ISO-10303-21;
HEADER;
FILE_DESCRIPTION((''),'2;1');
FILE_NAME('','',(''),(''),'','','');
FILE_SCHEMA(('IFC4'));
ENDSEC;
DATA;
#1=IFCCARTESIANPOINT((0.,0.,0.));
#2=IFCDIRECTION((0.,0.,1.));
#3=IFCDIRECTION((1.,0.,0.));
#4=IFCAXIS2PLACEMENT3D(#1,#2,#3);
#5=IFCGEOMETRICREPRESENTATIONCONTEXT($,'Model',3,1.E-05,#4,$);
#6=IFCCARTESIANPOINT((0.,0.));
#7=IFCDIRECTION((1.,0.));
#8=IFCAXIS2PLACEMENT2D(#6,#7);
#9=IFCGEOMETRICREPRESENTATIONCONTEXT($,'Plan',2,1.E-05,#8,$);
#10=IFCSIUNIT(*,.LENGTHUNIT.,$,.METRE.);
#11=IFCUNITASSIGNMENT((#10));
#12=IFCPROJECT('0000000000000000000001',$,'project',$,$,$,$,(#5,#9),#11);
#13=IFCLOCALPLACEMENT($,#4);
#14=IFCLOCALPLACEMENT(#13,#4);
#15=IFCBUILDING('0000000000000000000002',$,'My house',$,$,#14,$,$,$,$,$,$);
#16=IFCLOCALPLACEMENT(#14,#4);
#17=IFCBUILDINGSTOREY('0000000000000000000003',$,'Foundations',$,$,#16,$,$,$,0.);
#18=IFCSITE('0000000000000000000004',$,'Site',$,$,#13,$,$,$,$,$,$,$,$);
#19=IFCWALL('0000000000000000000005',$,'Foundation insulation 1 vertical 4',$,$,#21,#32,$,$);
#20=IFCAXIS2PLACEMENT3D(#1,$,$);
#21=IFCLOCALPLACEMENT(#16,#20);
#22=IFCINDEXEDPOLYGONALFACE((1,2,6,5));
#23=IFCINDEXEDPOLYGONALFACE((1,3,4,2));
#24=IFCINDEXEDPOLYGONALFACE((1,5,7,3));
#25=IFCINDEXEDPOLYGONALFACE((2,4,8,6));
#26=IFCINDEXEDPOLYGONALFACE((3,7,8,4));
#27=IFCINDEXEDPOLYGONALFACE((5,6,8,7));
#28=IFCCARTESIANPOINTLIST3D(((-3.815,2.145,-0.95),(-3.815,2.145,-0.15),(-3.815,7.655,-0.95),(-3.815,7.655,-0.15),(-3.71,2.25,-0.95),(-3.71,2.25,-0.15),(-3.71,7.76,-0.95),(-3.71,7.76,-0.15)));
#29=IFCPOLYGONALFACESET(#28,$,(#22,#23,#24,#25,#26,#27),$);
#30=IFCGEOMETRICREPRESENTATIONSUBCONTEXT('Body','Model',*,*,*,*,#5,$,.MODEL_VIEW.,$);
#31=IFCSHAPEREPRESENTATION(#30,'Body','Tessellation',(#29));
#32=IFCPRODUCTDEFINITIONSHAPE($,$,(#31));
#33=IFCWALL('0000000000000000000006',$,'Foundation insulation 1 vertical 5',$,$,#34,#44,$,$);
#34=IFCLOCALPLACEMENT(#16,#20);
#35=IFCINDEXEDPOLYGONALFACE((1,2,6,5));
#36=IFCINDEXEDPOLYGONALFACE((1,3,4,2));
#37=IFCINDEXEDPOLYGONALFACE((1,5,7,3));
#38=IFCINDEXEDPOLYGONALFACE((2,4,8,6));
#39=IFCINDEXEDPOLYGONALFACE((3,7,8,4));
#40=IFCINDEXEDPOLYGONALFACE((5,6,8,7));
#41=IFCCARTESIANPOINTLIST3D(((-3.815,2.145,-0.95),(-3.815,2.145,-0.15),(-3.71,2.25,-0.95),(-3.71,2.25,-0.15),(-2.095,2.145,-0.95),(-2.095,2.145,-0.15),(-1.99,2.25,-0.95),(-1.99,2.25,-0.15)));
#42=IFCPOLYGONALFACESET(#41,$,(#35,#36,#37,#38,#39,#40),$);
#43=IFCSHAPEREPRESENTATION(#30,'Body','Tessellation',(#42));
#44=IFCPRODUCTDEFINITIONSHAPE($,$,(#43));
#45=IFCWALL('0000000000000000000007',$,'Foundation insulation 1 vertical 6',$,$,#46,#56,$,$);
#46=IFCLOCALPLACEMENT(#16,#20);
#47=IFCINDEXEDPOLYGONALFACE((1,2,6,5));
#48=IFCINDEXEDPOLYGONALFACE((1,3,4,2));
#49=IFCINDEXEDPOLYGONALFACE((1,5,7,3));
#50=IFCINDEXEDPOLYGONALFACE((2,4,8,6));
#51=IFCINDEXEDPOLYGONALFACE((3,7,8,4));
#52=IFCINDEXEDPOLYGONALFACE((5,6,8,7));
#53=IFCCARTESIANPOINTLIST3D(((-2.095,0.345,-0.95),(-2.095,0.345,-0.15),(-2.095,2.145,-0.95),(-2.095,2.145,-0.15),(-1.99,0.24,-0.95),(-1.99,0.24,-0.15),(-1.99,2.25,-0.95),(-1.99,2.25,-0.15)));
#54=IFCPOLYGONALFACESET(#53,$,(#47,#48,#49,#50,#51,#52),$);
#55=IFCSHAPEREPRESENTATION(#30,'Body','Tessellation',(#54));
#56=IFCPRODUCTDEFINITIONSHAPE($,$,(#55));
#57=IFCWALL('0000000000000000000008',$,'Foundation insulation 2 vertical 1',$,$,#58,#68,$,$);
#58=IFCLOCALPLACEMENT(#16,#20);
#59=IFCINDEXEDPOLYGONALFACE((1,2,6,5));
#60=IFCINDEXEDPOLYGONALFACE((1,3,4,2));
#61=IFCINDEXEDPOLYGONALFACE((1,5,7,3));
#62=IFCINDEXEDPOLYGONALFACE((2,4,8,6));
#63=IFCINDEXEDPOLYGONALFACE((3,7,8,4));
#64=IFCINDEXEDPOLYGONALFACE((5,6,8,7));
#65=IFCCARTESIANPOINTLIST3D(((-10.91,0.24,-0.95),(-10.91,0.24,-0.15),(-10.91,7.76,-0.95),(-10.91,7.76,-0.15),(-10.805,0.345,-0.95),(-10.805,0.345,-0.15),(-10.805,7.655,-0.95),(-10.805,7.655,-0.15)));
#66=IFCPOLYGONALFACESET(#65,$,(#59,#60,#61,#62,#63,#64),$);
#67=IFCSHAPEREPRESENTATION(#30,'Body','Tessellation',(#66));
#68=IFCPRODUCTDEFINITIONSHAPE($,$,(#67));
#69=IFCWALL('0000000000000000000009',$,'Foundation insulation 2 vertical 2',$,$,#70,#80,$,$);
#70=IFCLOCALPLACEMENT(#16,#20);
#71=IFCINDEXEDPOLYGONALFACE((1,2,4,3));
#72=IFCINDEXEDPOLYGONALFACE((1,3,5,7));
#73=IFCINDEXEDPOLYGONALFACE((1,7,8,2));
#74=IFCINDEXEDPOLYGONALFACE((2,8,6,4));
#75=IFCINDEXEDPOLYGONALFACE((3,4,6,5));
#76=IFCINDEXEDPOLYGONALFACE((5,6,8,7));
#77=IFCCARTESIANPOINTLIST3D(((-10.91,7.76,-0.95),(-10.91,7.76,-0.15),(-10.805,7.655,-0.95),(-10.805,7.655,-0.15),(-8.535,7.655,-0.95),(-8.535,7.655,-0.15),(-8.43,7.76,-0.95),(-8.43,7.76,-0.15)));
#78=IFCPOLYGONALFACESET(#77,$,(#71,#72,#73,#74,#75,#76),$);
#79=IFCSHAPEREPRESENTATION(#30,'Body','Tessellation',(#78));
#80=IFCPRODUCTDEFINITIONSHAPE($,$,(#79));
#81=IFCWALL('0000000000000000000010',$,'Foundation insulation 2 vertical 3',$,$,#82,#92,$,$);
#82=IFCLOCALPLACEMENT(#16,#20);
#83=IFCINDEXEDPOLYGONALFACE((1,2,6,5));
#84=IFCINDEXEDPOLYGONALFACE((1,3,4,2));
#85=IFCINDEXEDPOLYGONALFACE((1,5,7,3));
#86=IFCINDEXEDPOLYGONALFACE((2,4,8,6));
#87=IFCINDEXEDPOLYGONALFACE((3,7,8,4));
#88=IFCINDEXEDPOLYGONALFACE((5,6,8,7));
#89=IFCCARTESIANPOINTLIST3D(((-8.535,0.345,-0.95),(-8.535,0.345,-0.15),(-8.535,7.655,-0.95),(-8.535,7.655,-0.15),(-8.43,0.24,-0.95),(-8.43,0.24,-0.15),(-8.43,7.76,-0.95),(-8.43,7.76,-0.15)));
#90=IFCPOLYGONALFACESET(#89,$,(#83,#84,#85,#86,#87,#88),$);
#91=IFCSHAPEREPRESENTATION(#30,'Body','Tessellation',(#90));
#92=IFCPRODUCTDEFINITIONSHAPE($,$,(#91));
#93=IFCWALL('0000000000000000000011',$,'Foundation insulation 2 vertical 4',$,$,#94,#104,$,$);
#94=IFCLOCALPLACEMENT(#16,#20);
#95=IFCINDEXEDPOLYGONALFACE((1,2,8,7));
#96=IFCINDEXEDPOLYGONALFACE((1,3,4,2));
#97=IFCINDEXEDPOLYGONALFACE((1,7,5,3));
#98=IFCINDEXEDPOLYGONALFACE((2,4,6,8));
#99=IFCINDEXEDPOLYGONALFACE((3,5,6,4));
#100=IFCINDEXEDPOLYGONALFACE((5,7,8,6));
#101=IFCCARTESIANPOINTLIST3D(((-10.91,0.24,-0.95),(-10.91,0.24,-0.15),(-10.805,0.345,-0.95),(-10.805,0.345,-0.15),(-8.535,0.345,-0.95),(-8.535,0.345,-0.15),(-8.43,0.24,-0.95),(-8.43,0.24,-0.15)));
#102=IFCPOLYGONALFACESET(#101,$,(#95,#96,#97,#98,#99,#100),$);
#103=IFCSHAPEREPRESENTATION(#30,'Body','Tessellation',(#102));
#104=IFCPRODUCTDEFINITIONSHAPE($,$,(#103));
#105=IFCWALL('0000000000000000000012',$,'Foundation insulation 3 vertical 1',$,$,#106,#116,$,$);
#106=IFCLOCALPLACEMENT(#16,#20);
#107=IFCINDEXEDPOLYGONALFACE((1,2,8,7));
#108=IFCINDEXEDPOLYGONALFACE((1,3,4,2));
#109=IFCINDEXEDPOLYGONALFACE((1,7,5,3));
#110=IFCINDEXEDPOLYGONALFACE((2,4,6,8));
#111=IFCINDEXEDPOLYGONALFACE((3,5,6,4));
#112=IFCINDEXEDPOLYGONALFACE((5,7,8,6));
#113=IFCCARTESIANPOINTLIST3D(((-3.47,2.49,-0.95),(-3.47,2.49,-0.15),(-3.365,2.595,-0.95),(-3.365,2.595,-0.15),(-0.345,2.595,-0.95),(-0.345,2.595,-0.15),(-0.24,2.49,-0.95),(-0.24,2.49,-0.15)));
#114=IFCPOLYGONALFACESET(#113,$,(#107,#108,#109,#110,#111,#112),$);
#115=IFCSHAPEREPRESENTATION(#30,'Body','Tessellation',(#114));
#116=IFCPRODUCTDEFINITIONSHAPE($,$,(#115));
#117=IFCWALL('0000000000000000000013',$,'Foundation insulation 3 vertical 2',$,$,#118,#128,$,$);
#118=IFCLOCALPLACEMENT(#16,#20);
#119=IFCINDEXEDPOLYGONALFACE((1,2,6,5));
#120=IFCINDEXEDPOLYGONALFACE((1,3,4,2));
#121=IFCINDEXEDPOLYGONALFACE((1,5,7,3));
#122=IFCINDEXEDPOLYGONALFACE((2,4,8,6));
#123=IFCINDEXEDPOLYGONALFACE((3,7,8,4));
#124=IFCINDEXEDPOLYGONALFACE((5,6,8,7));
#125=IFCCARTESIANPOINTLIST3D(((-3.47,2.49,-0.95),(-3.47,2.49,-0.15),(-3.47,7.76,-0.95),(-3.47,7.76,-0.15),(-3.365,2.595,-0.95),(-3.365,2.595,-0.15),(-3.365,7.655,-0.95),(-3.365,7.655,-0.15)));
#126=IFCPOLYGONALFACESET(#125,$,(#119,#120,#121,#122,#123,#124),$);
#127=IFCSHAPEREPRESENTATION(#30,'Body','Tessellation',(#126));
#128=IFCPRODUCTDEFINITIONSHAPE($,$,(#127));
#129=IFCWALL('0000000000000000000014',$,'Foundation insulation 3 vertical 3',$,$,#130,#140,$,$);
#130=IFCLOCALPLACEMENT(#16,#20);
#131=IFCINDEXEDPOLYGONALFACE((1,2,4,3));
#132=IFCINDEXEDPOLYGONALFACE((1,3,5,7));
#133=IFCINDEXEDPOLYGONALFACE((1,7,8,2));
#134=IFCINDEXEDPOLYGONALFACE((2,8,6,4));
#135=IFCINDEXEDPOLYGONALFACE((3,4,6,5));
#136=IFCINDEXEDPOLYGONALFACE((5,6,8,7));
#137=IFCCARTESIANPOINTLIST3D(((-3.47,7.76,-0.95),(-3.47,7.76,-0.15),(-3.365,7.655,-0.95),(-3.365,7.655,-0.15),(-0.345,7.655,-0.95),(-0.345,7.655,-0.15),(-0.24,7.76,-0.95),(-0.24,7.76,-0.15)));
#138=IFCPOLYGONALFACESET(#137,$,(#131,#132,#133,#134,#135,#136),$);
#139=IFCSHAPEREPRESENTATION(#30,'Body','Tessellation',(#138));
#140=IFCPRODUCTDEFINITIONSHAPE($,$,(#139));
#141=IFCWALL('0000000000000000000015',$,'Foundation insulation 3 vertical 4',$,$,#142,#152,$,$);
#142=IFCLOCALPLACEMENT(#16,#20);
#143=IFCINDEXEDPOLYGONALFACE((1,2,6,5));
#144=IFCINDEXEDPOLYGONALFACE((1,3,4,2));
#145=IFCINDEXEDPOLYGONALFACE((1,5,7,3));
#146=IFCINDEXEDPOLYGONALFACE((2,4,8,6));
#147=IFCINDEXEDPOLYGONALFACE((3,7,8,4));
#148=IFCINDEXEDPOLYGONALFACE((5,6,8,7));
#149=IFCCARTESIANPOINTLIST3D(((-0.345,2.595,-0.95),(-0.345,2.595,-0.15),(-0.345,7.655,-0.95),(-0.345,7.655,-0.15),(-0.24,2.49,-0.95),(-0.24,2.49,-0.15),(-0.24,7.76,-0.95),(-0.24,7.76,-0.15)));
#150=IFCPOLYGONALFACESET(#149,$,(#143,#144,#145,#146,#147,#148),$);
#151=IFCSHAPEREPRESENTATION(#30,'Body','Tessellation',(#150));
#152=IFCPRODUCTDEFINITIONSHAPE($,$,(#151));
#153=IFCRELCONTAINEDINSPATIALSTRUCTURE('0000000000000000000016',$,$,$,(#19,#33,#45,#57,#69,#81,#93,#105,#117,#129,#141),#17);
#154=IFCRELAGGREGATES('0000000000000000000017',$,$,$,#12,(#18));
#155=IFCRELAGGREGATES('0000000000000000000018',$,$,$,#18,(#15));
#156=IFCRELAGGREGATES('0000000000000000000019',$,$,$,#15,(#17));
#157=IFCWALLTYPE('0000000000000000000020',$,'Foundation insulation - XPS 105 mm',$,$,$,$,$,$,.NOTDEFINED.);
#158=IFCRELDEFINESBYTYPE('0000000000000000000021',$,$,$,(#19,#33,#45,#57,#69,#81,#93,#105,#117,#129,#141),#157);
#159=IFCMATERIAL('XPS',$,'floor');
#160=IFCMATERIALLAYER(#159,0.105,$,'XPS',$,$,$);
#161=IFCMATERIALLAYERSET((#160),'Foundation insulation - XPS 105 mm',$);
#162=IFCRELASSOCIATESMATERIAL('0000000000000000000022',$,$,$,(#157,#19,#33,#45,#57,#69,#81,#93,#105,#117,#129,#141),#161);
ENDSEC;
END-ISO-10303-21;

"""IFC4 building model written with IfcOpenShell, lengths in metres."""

from ifc_helpers import new_model, si_unit, frame, origin_with_axes, origin_2d_with_axis, place, context, subcontext, project, spatial, line, indexed_curve, outline, extrude, source, transform, mapped, material, layer, layer_set, layer_usage, type_object, element, save


model = new_model("IFC4")

# Units and contexts
model_context = context("Model", 3, precision=1e-05, world=origin_with_axes())
plan_context = context("Plan", 2, precision=1e-05, world=origin_2d_with_axis())
body_context = subcontext(model_context, "Body", "Model", "MODEL_VIEW")
ifc_project = project(units=[si_unit("LENGTHUNIT", "METRE")], contexts=[model_context, plan_context])

# Site, building, storey
site_placement = place(None, origin_with_axes())
site = spatial("IfcSite", under=ifc_project, at=site_placement, Name="Site")
building_placement = place(site_placement, origin_with_axes())
building = spatial("IfcBuilding", under=site, at=building_placement, Name="My house")
storey_placement = place(building_placement, origin_with_axes())
storey = spatial("IfcBuildingStorey", under=building, at=storey_placement, Name="Foundations", Elevation=0.0)

# Shared definitions
ifc_material_1 = material(Name="XPS", Category="floor")

# Walls
ifc_layer_1 = layer(ifc_material_1, 0.105, Name="XPS")
ifc_layer_set_1 = layer_set([ifc_layer_1], Name="Foundation insulation - XPS 105 mm")
wall_type_1 = type_object("IfcWallType", Name="Foundation insulation - XPS 105 mm", PredefinedType="NOTDEFINED", material=ifc_layer_set_1)
ifc_layer_usage_1 = layer_usage(ifc_layer_set_1, "AXIS2", "NEGATIVE", 0.105)
shared_shape_1 = source(origin_with_axes(), body_context, "Body", "SweptSolid", [
    extrude(outline(indexed_curve([(0.0, 0.0), (0.105, 0.105), (5.615, 0.105), (5.51, 0.0)], segments=[line(1, 2, 3, 4, 1)])), origin_with_axes(), (0.0, 0.0, 1.0), 0.8),
])
wall_1_placement = place(storey_placement, frame((-3.71, 7.76, -0.95), z_axis=(0.0, 0.0, 1.0), x_axis=(0.0, 1.0, 0.0)))
element("IfcWall", 1, at=wall_1_placement, inside=storey, type_object=wall_type_1, material=ifc_layer_usage_1, Name="Foundation insulation 1 vertical 4", context=body_context, shape_type="MappedRepresentation", body=[
    mapped(shared_shape_1, transform((0.0, 0.0, 0.0), x_axis=(-1.0, 0.0, 0.0), y_axis=(0.0, 1.0, 0.0), z_axis=(0.0, 0.0, 1.0), scale=1.0)),
])
ifc_layer_usage_2 = layer_usage(ifc_layer_set_1, "AXIS2", "NEGATIVE", 0.105)
shared_shape_2 = source(origin_with_axes(), body_context, "Body", "SweptSolid", [
    extrude(outline(indexed_curve([(0.0, 0.0), (-0.105, 0.105), (1.615, 0.105), (1.72, 0.0)], segments=[line(1, 2, 3, 4, 1)])), origin_with_axes(), (0.0, 0.0, 1.0), 0.8),
])
wall_2_placement = place(storey_placement, frame((-3.71, 2.25, -0.95), z_axis=(0.0, 0.0, 1.0), x_axis=(-1.0, 0.0, 0.0)))
element("IfcWall", 2, at=wall_2_placement, inside=storey, type_object=wall_type_1, material=ifc_layer_usage_2, Name="Foundation insulation 1 vertical 5", context=body_context, shape_type="MappedRepresentation", body=[
    mapped(shared_shape_2, transform((0.0, 0.0, 0.0), x_axis=(-1.0, 0.0, 0.0), y_axis=(0.0, 1.0, 0.0), z_axis=(0.0, 0.0, 1.0), scale=1.0)),
])
ifc_layer_usage_3 = layer_usage(ifc_layer_set_1, "AXIS2", "NEGATIVE", 0.105)
shared_shape_3 = source(origin_with_axes(), body_context, "Body", "SweptSolid", [
    extrude(outline(indexed_curve([(0.0, 0.0), (0.105, 0.105), (1.905, 0.105), (2.01, 0.0)], segments=[line(1, 2, 3, 4, 1)])), origin_with_axes(), (0.0, 0.0, 1.0), 0.8),
])
wall_3_placement = place(storey_placement, frame((-1.99, 2.25, -0.95), z_axis=(0.0, 0.0, 1.0), x_axis=(0.0, 1.0, 0.0)))
element("IfcWall", 3, at=wall_3_placement, inside=storey, type_object=wall_type_1, material=ifc_layer_usage_3, Name="Foundation insulation 1 vertical 6", context=body_context, shape_type="MappedRepresentation", body=[
    mapped(shared_shape_3, transform((0.0, 0.0, 0.0), x_axis=(-1.0, 0.0, 0.0), y_axis=(0.0, 1.0, 0.0), z_axis=(0.0, 0.0, 1.0), scale=1.0)),
])
ifc_layer_usage_4 = layer_usage(ifc_layer_set_1, "AXIS2", "NEGATIVE", 0.105)
shared_shape_4 = source(origin_with_axes(), body_context, "Body", "SweptSolid", [
    extrude(outline(indexed_curve([(0.0, 0.0), (0.105, 0.105), (7.415, 0.105), (7.52, 0.0)], segments=[line(1, 2, 3, 4, 1)])), origin_with_axes(), (0.0, 0.0, 1.0), 0.8),
])
wall_4_placement = place(storey_placement, frame((-10.91, 0.24, -0.95), z_axis=(0.0, 0.0, 1.0), x_axis=(0.0, -1.0, 0.0)))
element("IfcWall", 4, at=wall_4_placement, inside=storey, type_object=wall_type_1, material=ifc_layer_usage_4, Name="Foundation insulation 2 vertical 1", context=body_context, shape_type="MappedRepresentation", body=[
    mapped(shared_shape_4, transform((0.0, 0.0, 0.0), x_axis=(-1.0, 0.0, 0.0), y_axis=(0.0, 1.0, 0.0), z_axis=(0.0, 0.0, 1.0), scale=1.0)),
])
ifc_layer_usage_5 = layer_usage(ifc_layer_set_1, "AXIS2", "NEGATIVE", 0.105)
shared_shape_5 = source(origin_with_axes(), body_context, "Body", "SweptSolid", [
    extrude(outline(indexed_curve([(0.0, 0.0), (0.105, 0.105), (2.375, 0.105), (2.48, 0.0)], segments=[line(1, 2, 3, 4, 1)])), origin_with_axes(), (0.0, 0.0, 1.0), 0.8),
])
wall_5_placement = place(storey_placement, frame((-10.91, 7.76, -0.95), z_axis=(0.0, 0.0, 1.0), x_axis=(-1.0, 0.0, 0.0)))
element("IfcWall", 5, at=wall_5_placement, inside=storey, type_object=wall_type_1, material=ifc_layer_usage_5, Name="Foundation insulation 2 vertical 2", context=body_context, shape_type="MappedRepresentation", body=[
    mapped(shared_shape_5, transform((0.0, 0.0, 0.0), x_axis=(-1.0, 0.0, 0.0), y_axis=(0.0, 1.0, 0.0), z_axis=(0.0, 0.0, 1.0), scale=1.0)),
])
ifc_layer_usage_6 = layer_usage(ifc_layer_set_1, "AXIS2", "NEGATIVE", 0.105)
shared_shape_6 = source(origin_with_axes(), body_context, "Body", "SweptSolid", [
    extrude(outline(indexed_curve([(0.0, 0.0), (0.105, 0.105), (7.415, 0.105), (7.52, 0.0)], segments=[line(1, 2, 3, 4, 1)])), origin_with_axes(), (0.0, 0.0, 1.0), 0.8),
])
wall_6_placement = place(storey_placement, frame((-8.43, 7.76, -0.95), z_axis=(0.0, 0.0, 1.0), x_axis=(0.0, 1.0, 0.0)))
element("IfcWall", 6, at=wall_6_placement, inside=storey, type_object=wall_type_1, material=ifc_layer_usage_6, Name="Foundation insulation 2 vertical 3", context=body_context, shape_type="MappedRepresentation", body=[
    mapped(shared_shape_6, transform((0.0, 0.0, 0.0), x_axis=(-1.0, 0.0, 0.0), y_axis=(0.0, 1.0, 0.0), z_axis=(0.0, 0.0, 1.0), scale=1.0)),
])
ifc_layer_usage_7 = layer_usage(ifc_layer_set_1, "AXIS2", "NEGATIVE", 0.105)
shared_shape_7 = source(origin_with_axes(), body_context, "Body", "SweptSolid", [
    extrude(outline(indexed_curve([(0.0, 0.0), (0.105, 0.105), (2.375, 0.105), (2.48, 0.0)], segments=[line(1, 2, 3, 4, 1)])), origin_with_axes(), (0.0, 0.0, 1.0), 0.8),
])
wall_7_placement = place(storey_placement, frame((-8.43, 0.24, -0.95), z_axis=(0.0, 0.0, 1.0), x_axis=(1.0, 0.0, 0.0)))
element("IfcWall", 7, at=wall_7_placement, inside=storey, type_object=wall_type_1, material=ifc_layer_usage_7, Name="Foundation insulation 2 vertical 4", context=body_context, shape_type="MappedRepresentation", body=[
    mapped(shared_shape_7, transform((0.0, 0.0, 0.0), x_axis=(-1.0, 0.0, 0.0), y_axis=(0.0, 1.0, 0.0), z_axis=(0.0, 0.0, 1.0), scale=1.0)),
])
ifc_layer_usage_8 = layer_usage(ifc_layer_set_1, "AXIS2", "NEGATIVE", 0.105)
shared_shape_8 = source(origin_with_axes(), body_context, "Body", "SweptSolid", [
    extrude(outline(indexed_curve([(0.0, 0.0), (0.105, 0.105), (3.125, 0.105), (3.23, 0.0)], segments=[line(1, 2, 3, 4, 1)])), origin_with_axes(), (0.0, 0.0, 1.0), 0.8),
])
wall_8_placement = place(storey_placement, frame((-0.24, 2.49, -0.95), z_axis=(0.0, 0.0, 1.0), x_axis=(1.0, 0.0, 0.0)))
element("IfcWall", 8, at=wall_8_placement, inside=storey, type_object=wall_type_1, material=ifc_layer_usage_8, Name="Foundation insulation 3 vertical 1", context=body_context, shape_type="MappedRepresentation", body=[
    mapped(shared_shape_8, transform((0.0, 0.0, 0.0), x_axis=(-1.0, 0.0, 0.0), y_axis=(0.0, 1.0, 0.0), z_axis=(0.0, 0.0, 1.0), scale=1.0)),
])
ifc_layer_usage_9 = layer_usage(ifc_layer_set_1, "AXIS2", "NEGATIVE", 0.105)
shared_shape_9 = source(origin_with_axes(), body_context, "Body", "SweptSolid", [
    extrude(outline(indexed_curve([(0.0, 0.0), (0.105, 0.105), (5.165, 0.105), (5.27, 0.0)], segments=[line(1, 2, 3, 4, 1)])), origin_with_axes(), (0.0, 0.0, 1.0), 0.8),
])
wall_9_placement = place(storey_placement, frame((-3.47, 2.49, -0.95), z_axis=(0.0, 0.0, 1.0), x_axis=(0.0, -1.0, 0.0)))
element("IfcWall", 9, at=wall_9_placement, inside=storey, type_object=wall_type_1, material=ifc_layer_usage_9, Name="Foundation insulation 3 vertical 2", context=body_context, shape_type="MappedRepresentation", body=[
    mapped(shared_shape_9, transform((0.0, 0.0, 0.0), x_axis=(-1.0, 0.0, 0.0), y_axis=(0.0, 1.0, 0.0), z_axis=(0.0, 0.0, 1.0), scale=1.0)),
])
ifc_layer_usage_10 = layer_usage(ifc_layer_set_1, "AXIS2", "NEGATIVE", 0.105)
shared_shape_10 = source(origin_with_axes(), body_context, "Body", "SweptSolid", [
    extrude(outline(indexed_curve([(0.0, 0.0), (0.105, 0.105), (3.125, 0.105), (3.23, 0.0)], segments=[line(1, 2, 3, 4, 1)])), origin_with_axes(), (0.0, 0.0, 1.0), 0.8),
])
wall_10_placement = place(storey_placement, frame((-3.47, 7.76, -0.95), z_axis=(0.0, 0.0, 1.0), x_axis=(-1.0, 0.0, 0.0)))
element("IfcWall", 10, at=wall_10_placement, inside=storey, type_object=wall_type_1, material=ifc_layer_usage_10, Name="Foundation insulation 3 vertical 3", context=body_context, shape_type="MappedRepresentation", body=[
    mapped(shared_shape_10, transform((0.0, 0.0, 0.0), x_axis=(-1.0, 0.0, 0.0), y_axis=(0.0, 1.0, 0.0), z_axis=(0.0, 0.0, 1.0), scale=1.0)),
])
ifc_layer_usage_11 = layer_usage(ifc_layer_set_1, "AXIS2", "NEGATIVE", 0.105)
shared_shape_11 = source(origin_with_axes(), body_context, "Body", "SweptSolid", [
    extrude(outline(indexed_curve([(0.0, 0.0), (0.105, 0.105), (5.165, 0.105), (5.27, 0.0)], segments=[line(1, 2, 3, 4, 1)])), origin_with_axes(), (0.0, 0.0, 1.0), 0.8),
])
wall_11_placement = place(storey_placement, frame((-0.24, 7.76, -0.95), z_axis=(0.0, 0.0, 1.0), x_axis=(0.0, 1.0, 0.0)))
element("IfcWall", 11, at=wall_11_placement, inside=storey, type_object=wall_type_1, material=ifc_layer_usage_11, Name="Foundation insulation 3 vertical 4", context=body_context, shape_type="MappedRepresentation", body=[
    mapped(shared_shape_11, transform((0.0, 0.0, 0.0), x_axis=(-1.0, 0.0, 0.0), y_axis=(0.0, 1.0, 0.0), z_axis=(0.0, 0.0, 1.0), scale=1.0)),
])

save(model, "model.ifc")
